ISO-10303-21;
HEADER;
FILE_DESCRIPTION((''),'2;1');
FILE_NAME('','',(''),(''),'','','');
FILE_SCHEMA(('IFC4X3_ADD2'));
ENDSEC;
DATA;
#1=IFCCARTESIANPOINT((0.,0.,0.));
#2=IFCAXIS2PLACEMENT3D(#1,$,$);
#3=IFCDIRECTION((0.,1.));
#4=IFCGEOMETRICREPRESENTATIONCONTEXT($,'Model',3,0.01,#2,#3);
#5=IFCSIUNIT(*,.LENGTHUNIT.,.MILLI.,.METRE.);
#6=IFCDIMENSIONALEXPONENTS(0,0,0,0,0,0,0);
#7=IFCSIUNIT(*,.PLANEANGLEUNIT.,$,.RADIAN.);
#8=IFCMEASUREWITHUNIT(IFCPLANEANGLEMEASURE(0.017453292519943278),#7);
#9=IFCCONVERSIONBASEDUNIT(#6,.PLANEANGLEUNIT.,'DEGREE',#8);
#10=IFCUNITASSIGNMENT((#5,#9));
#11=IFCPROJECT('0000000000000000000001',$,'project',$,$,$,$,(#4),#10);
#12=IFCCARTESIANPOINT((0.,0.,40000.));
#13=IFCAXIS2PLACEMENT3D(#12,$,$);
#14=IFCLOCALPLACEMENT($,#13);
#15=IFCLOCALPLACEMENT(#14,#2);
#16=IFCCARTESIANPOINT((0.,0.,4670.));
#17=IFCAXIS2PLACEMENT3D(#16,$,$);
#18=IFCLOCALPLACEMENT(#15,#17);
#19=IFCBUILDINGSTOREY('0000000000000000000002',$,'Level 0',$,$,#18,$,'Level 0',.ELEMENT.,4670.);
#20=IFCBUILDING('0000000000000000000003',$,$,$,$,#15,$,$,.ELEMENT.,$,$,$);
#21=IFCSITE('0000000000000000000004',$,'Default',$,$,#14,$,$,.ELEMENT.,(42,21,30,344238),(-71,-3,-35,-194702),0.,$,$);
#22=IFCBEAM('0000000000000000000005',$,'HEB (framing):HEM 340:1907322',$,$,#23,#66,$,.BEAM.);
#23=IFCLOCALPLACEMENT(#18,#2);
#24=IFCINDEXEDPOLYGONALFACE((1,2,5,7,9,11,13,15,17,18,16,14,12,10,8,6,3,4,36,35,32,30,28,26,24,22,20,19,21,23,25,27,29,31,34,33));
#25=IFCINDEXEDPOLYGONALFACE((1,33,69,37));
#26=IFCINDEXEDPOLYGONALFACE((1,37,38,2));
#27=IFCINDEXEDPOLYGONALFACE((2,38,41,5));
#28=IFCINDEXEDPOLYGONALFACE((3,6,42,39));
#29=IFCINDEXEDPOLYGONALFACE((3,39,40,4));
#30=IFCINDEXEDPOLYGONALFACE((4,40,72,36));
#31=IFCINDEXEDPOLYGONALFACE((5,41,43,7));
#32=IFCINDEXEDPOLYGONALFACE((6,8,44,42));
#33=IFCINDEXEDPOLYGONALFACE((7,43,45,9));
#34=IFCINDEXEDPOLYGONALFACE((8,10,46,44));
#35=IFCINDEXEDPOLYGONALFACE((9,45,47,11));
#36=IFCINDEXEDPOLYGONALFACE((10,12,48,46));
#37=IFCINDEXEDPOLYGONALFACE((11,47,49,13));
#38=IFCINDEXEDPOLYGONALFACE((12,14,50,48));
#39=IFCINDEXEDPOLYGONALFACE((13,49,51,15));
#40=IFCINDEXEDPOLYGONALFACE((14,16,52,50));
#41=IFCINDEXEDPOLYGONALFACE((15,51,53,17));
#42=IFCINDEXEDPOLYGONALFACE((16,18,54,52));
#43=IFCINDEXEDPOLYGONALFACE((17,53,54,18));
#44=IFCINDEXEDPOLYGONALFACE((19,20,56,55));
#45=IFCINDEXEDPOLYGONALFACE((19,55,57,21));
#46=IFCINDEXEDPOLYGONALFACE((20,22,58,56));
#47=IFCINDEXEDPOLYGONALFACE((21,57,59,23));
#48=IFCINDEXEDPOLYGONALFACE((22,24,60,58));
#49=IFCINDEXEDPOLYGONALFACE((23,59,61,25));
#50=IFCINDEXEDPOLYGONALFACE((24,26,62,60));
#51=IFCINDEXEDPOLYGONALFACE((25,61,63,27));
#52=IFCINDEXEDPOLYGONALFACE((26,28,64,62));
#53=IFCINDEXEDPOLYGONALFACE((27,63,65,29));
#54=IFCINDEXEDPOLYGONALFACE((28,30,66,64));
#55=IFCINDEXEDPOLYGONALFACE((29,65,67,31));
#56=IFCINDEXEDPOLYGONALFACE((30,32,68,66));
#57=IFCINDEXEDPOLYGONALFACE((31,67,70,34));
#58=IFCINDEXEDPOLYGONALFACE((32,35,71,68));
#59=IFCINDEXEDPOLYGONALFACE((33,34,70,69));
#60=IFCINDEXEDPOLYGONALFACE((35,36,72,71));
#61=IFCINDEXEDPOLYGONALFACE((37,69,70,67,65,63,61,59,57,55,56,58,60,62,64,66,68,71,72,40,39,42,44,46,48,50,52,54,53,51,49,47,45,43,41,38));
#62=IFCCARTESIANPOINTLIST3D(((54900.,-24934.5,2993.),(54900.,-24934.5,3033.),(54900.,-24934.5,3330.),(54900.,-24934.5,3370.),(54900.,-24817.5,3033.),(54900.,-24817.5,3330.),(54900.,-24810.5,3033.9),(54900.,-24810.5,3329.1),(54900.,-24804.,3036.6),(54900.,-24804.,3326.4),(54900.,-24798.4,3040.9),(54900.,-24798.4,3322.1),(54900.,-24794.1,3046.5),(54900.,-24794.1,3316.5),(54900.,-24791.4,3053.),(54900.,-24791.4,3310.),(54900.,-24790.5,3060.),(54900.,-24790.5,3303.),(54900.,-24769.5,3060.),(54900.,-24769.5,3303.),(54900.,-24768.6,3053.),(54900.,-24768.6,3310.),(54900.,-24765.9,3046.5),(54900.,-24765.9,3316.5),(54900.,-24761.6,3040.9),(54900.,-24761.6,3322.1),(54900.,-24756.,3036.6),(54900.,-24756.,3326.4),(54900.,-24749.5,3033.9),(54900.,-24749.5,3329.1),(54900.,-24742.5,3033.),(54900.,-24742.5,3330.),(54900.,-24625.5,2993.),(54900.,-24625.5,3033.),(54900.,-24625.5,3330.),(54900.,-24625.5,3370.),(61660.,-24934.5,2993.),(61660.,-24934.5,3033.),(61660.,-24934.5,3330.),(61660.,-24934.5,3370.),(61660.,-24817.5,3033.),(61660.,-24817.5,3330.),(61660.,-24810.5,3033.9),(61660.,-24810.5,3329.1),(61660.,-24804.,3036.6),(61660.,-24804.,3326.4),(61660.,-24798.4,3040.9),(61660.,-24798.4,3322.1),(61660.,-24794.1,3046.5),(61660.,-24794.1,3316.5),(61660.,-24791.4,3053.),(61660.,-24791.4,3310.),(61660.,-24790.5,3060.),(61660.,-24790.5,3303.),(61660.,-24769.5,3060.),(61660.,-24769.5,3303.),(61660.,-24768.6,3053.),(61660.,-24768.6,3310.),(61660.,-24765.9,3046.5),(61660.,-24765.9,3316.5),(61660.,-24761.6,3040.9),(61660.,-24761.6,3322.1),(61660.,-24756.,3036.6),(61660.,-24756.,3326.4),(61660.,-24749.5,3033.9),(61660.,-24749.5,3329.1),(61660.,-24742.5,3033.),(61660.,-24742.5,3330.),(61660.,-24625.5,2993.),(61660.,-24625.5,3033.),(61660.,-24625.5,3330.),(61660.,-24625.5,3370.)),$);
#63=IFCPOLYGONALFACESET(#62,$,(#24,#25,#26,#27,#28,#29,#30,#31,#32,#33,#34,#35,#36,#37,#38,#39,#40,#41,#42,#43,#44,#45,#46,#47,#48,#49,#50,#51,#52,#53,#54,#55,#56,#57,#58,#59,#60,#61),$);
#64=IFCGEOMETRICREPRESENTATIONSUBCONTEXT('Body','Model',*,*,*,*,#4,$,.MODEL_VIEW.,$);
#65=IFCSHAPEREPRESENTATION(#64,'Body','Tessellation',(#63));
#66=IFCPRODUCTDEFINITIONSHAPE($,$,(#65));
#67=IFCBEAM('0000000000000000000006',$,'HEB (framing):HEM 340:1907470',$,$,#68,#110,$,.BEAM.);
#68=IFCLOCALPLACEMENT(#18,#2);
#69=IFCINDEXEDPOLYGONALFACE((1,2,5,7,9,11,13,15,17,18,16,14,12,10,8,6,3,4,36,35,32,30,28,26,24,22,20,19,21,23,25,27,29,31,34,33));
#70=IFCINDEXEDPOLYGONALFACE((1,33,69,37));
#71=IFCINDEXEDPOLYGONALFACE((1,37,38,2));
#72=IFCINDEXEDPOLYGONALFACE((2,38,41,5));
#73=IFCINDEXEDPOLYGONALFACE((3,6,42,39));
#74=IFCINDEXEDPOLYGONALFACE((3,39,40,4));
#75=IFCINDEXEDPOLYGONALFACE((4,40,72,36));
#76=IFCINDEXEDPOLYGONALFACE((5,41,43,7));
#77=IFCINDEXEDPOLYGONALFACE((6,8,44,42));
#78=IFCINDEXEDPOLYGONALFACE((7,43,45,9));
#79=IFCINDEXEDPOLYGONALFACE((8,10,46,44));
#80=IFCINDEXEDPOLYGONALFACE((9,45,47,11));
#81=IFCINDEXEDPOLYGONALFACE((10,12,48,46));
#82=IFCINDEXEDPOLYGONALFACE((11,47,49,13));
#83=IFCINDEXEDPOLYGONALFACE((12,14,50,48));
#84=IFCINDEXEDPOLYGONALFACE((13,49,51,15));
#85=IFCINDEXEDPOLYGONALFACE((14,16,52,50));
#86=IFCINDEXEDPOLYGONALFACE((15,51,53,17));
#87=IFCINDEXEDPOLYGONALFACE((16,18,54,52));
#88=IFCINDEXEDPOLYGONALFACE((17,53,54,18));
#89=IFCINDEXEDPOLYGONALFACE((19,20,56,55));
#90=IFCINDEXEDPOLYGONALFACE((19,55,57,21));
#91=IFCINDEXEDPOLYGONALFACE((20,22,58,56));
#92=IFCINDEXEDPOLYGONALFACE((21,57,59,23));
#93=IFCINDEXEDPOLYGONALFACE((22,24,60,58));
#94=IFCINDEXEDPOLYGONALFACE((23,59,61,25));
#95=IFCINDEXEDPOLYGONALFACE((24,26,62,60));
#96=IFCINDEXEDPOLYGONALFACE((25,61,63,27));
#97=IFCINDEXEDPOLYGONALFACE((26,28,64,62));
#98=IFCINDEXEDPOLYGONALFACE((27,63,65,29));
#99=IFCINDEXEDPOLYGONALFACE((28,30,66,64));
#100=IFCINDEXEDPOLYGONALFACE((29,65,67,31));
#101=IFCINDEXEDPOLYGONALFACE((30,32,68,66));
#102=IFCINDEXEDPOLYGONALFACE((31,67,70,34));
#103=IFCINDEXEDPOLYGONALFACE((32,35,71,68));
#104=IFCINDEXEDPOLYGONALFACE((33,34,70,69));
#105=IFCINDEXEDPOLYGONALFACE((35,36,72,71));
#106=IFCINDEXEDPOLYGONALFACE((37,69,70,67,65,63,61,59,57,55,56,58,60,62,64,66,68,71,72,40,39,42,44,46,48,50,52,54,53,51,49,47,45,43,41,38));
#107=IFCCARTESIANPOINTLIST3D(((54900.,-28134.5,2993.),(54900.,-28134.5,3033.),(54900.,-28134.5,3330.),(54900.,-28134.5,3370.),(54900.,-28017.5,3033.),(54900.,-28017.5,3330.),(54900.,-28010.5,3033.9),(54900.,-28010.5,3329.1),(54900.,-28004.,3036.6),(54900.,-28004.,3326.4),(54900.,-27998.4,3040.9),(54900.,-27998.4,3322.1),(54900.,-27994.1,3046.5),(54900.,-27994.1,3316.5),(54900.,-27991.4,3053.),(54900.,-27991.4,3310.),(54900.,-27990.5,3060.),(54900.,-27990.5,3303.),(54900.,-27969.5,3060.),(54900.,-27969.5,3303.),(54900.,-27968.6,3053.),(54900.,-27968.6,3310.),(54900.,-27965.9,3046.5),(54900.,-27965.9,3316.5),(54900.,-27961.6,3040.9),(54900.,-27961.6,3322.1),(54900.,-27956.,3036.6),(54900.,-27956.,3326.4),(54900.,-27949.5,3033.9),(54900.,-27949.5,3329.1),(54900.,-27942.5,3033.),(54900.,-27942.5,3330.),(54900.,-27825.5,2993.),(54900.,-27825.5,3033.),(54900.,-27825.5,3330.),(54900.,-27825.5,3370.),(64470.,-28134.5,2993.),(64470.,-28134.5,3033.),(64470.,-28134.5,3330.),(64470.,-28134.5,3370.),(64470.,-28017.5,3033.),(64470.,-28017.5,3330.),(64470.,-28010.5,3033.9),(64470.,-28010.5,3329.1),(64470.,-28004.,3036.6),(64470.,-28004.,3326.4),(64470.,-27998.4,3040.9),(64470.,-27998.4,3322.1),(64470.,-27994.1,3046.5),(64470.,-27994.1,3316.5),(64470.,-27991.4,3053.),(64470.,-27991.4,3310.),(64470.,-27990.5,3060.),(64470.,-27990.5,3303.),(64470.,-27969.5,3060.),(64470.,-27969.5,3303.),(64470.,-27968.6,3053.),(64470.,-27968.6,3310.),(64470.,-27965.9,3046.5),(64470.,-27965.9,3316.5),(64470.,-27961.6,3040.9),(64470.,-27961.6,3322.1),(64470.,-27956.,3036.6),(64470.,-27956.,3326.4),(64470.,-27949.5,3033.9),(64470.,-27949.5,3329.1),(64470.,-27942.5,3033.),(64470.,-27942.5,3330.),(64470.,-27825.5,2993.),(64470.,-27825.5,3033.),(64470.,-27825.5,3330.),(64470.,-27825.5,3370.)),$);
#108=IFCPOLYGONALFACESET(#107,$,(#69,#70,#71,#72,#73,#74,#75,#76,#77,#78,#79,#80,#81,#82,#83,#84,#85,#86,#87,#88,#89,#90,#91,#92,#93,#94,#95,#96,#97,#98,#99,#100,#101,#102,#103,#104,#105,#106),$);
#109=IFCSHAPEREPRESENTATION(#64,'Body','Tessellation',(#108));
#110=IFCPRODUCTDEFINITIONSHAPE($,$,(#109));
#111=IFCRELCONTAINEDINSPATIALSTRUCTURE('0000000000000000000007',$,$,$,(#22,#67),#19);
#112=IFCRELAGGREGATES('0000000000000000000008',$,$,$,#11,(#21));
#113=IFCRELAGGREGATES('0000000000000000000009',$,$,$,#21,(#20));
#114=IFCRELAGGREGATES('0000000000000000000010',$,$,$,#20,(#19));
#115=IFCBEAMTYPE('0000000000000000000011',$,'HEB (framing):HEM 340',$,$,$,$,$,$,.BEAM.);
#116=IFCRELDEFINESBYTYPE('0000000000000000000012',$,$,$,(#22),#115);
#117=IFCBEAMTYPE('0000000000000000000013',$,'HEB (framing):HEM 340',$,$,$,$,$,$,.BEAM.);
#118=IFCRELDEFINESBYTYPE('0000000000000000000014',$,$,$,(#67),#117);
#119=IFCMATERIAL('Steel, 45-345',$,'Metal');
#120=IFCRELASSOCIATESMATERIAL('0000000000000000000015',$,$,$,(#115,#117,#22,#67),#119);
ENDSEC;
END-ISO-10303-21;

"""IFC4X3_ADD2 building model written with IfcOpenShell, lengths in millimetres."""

from ifc_helpers import new_model, entity, si_unit, converted_unit, direction, frame, frame_2d, origin, place, context, subcontext, project, spatial, polyline, circle_curve, parameter, trimmed, segment, composite_curve, outline, extrude, source, transform, mapped, material, material_profile, profile_set, profile_usage, type_object, type_shapes, element, save


model = new_model("IFC4X3_ADD2")

# Units and contexts
model_context = context("Model", 3, precision=0.01, world=origin(), true_north=direction((0.0, 1.0)))
body_context = subcontext(model_context, "Body", "Model", "MODEL_VIEW")
ifc_project = project(units=[si_unit("LENGTHUNIT", "METRE", prefix="MILLI"), converted_unit("PLANEANGLEUNIT", "DEGREE", entity("IfcPlaneAngleMeasure", 0.017453292519943278), si_unit("PLANEANGLEUNIT", "RADIAN"), dimensions=[0, 0, 0, 0, 0, 0, 0])], contexts=[model_context])

# Site, building, storey
site_placement = place(None, frame((0.0, 0.0, 40000.0)))
site = spatial("IfcSite", under=ifc_project, at=site_placement, Name="Default", CompositionType="ELEMENT", RefLatitude=(42, 21, 30, 344238), RefLongitude=(-71, -3, -35, -194702), RefElevation=0.0)
building_placement = place(site_placement, origin())
building = spatial("IfcBuilding", under=site, at=building_placement, CompositionType="ELEMENT")
storey_placement = place(building_placement, frame((0.0, 0.0, 4670.0)))
storey = spatial("IfcBuildingStorey", under=building, at=storey_placement, Name="Level 0", LongName="Level 0", CompositionType="ELEMENT", Elevation=4670.0)

# Shared definitions
ifc_material_1 = material(Name="Steel, 45-345", Category="Metal")

# Beams
ifc_material_profile_1 = material_profile(ifc_material_1, outline(composite_curve([segment(polyline([(-154.5, -148.5), (-154.5, -188.5)]), True, "CONTINUOUS"), segment(polyline([(-154.5, -188.5), (154.5, -188.5)]), True, "CONTINUOUS"), segment(polyline([(154.5, -188.5), (154.5, -148.5)]), True, "CONTINUOUS"), segment(polyline([(154.5, -148.5), (37.5, -148.5)]), True, "CONTINUOUS"), segment(trimmed(circle_curve(frame_2d((37.5, -121.5), x_axis=(1.0, 0.0)), 27.0), [parameter(180.0)], [parameter(270.0)], True, "PARAMETER"), False, "CONTINUOUS"), segment(polyline([(10.5, -121.5), (10.5, 121.5)]), True, "CONTINUOUS"), segment(trimmed(circle_curve(frame_2d((37.5, 121.5), x_axis=(1.0, 0.0)), 27.0), [parameter(90.0)], [parameter(180.0)], True, "PARAMETER"), False, "CONTINUOUS"), segment(polyline([(37.5, 148.5), (154.5, 148.5)]), True, "CONTINUOUS"), segment(polyline([(154.5, 148.5), (154.5, 188.5)]), True, "CONTINUOUS"), segment(polyline([(154.5, 188.5), (-154.5, 188.5)]), True, "CONTINUOUS"), segment(polyline([(-154.5, 188.5), (-154.5, 148.5)]), True, "CONTINUOUS"), segment(polyline([(-154.5, 148.5), (-37.5, 148.5)]), True, "CONTINUOUS"), segment(trimmed(circle_curve(frame_2d((-37.5, 121.5), x_axis=(1.0, 0.0)), 27.0), [parameter(360.0)], [parameter(90.0)], True, "PARAMETER"), False, "CONTINUOUS"), segment(polyline([(-10.5, 121.5), (-10.5, -121.5)]), True, "CONTINUOUS"), segment(trimmed(circle_curve(frame_2d((-37.5, -121.5), x_axis=(1.0, 0.0)), 27.0), [parameter(270.0)], [parameter(0.0)], True, "PARAMETER"), False, "CONTINUOUS"), segment(polyline([(-37.5, -148.5), (-154.5, -148.5)]), True, "CONTINUOUS")], self_intersect=False)), Name="HEM 340")
ifc_profile_set_1 = profile_set([ifc_material_profile_1], Name="HEM 340")
ifc_profile_usage_1 = profile_usage(ifc_profile_set_1, cardinal=8)
beam_type_1 = type_object("IfcBeamType", Name="HEB (framing):HEM 340", PredefinedType="BEAM", material=ifc_profile_set_1)
shared_shape_1 = source(origin(), body_context, "Body", "SweptSolid", [
    extrude(outline(composite_curve([segment(polyline([(-154.5, -148.5), (-154.5, -188.5)]), True, "CONTINUOUS"), segment(polyline([(-154.5, -188.5), (154.5, -188.5)]), True, "CONTINUOUS"), segment(polyline([(154.5, -188.5), (154.5, -148.5)]), True, "CONTINUOUS"), segment(polyline([(154.5, -148.5), (37.5, -148.5)]), True, "CONTINUOUS"), segment(trimmed(circle_curve(frame_2d((37.5, -121.5), x_axis=(1.0, 0.0)), 27.0), [parameter(180.0)], [parameter(270.0)], True, "PARAMETER"), False, "CONTINUOUS"), segment(polyline([(10.5, -121.5), (10.5, 121.5)]), True, "CONTINUOUS"), segment(trimmed(circle_curve(frame_2d((37.5, 121.5), x_axis=(1.0, 0.0)), 27.0), [parameter(90.0)], [parameter(180.0)], True, "PARAMETER"), False, "CONTINUOUS"), segment(polyline([(37.5, 148.5), (154.5, 148.5)]), True, "CONTINUOUS"), segment(polyline([(154.5, 148.5), (154.5, 188.5)]), True, "CONTINUOUS"), segment(polyline([(154.5, 188.5), (-154.5, 188.5)]), True, "CONTINUOUS"), segment(polyline([(-154.5, 188.5), (-154.5, 148.5)]), True, "CONTINUOUS"), segment(polyline([(-154.5, 148.5), (-37.5, 148.5)]), True, "CONTINUOUS"), segment(trimmed(circle_curve(frame_2d((-37.5, 121.5), x_axis=(1.0, 0.0)), 27.0), [parameter(360.0)], [parameter(90.0)], True, "PARAMETER"), False, "CONTINUOUS"), segment(polyline([(-10.5, 121.5), (-10.5, -121.5)]), True, "CONTINUOUS"), segment(trimmed(circle_curve(frame_2d((-37.5, -121.5), x_axis=(1.0, 0.0)), 27.0), [parameter(270.0)], [parameter(0.0)], True, "PARAMETER"), False, "CONTINUOUS"), segment(polyline([(-37.5, -148.5), (-154.5, -148.5)]), True, "CONTINUOUS")], self_intersect=False)), frame((-3397.7, 0.0, 0.0), z_axis=(-1.0, 0.0, 0.0), x_axis=(0.0, -1.0, 0.0)), (0.0, 0.0, -1.0), 6760.0),
])
type_shapes(beam_type_1, [shared_shape_1])
beam_1_placement = place(storey_placement, frame((58297.7, -24780.0, 3181.5)))
element("IfcBeam", 1, at=beam_1_placement, inside=storey, type_object=beam_type_1, material=ifc_profile_usage_1, Name="HEB (framing):HEM 340:1907322", PredefinedType="BEAM", context=body_context, shape_type="MappedRepresentation", body=[
    mapped(shared_shape_1, transform((0.0, 0.0, 0.0), scale=1.0)),
])
beam_type_2 = type_object("IfcBeamType", Name="HEB (framing):HEM 340", PredefinedType="BEAM", material=ifc_profile_set_1)
shared_shape_2 = source(origin(), body_context, "Body", "SweptSolid", [
    extrude(outline(composite_curve([segment(polyline([(-154.5, -148.5), (-154.5, -188.5)]), True, "CONTINUOUS"), segment(polyline([(-154.5, -188.5), (154.5, -188.5)]), True, "CONTINUOUS"), segment(polyline([(154.5, -188.5), (154.5, -148.5)]), True, "CONTINUOUS"), segment(polyline([(154.5, -148.5), (37.5, -148.5)]), True, "CONTINUOUS"), segment(trimmed(circle_curve(frame_2d((37.5, -121.5), x_axis=(1.0, 0.0)), 27.0), [parameter(180.0)], [parameter(270.0)], True, "PARAMETER"), False, "CONTINUOUS"), segment(polyline([(10.5, -121.5), (10.5, 121.5)]), True, "CONTINUOUS"), segment(trimmed(circle_curve(frame_2d((37.5, 121.5), x_axis=(1.0, 0.0)), 27.0), [parameter(90.0)], [parameter(180.0)], True, "PARAMETER"), False, "CONTINUOUS"), segment(polyline([(37.5, 148.5), (154.5, 148.5)]), True, "CONTINUOUS"), segment(polyline([(154.5, 148.5), (154.5, 188.5)]), True, "CONTINUOUS"), segment(polyline([(154.5, 188.5), (-154.5, 188.5)]), True, "CONTINUOUS"), segment(polyline([(-154.5, 188.5), (-154.5, 148.5)]), True, "CONTINUOUS"), segment(polyline([(-154.5, 148.5), (-37.5, 148.5)]), True, "CONTINUOUS"), segment(trimmed(circle_curve(frame_2d((-37.5, 121.5), x_axis=(1.0, 0.0)), 27.0), [parameter(360.0)], [parameter(90.0)], True, "PARAMETER"), False, "CONTINUOUS"), segment(polyline([(-10.5, 121.5), (-10.5, -121.5)]), True, "CONTINUOUS"), segment(trimmed(circle_curve(frame_2d((-37.5, -121.5), x_axis=(1.0, 0.0)), 27.0), [parameter(270.0)], [parameter(0.0)], True, "PARAMETER"), False, "CONTINUOUS"), segment(polyline([(-37.5, -148.5), (-154.5, -148.5)]), True, "CONTINUOUS")], self_intersect=False)), frame((-4685.0, 0.0, 0.0), z_axis=(-1.0, 0.0, 0.0), x_axis=(0.0, -1.0, 0.0)), (0.0, 0.0, -1.0), 9570.0),
])
type_shapes(beam_type_2, [shared_shape_2])
beam_2_placement = place(storey_placement, frame((59585.0, -27980.0, 3181.5)))
element("IfcBeam", 2, at=beam_2_placement, inside=storey, type_object=beam_type_2, material=ifc_profile_usage_1, Name="HEB (framing):HEM 340:1907470", PredefinedType="BEAM", context=body_context, shape_type="MappedRepresentation", body=[
    mapped(shared_shape_2, transform((0.0, 0.0, 0.0), scale=1.0)),
])

save(model, "model.ifc")
